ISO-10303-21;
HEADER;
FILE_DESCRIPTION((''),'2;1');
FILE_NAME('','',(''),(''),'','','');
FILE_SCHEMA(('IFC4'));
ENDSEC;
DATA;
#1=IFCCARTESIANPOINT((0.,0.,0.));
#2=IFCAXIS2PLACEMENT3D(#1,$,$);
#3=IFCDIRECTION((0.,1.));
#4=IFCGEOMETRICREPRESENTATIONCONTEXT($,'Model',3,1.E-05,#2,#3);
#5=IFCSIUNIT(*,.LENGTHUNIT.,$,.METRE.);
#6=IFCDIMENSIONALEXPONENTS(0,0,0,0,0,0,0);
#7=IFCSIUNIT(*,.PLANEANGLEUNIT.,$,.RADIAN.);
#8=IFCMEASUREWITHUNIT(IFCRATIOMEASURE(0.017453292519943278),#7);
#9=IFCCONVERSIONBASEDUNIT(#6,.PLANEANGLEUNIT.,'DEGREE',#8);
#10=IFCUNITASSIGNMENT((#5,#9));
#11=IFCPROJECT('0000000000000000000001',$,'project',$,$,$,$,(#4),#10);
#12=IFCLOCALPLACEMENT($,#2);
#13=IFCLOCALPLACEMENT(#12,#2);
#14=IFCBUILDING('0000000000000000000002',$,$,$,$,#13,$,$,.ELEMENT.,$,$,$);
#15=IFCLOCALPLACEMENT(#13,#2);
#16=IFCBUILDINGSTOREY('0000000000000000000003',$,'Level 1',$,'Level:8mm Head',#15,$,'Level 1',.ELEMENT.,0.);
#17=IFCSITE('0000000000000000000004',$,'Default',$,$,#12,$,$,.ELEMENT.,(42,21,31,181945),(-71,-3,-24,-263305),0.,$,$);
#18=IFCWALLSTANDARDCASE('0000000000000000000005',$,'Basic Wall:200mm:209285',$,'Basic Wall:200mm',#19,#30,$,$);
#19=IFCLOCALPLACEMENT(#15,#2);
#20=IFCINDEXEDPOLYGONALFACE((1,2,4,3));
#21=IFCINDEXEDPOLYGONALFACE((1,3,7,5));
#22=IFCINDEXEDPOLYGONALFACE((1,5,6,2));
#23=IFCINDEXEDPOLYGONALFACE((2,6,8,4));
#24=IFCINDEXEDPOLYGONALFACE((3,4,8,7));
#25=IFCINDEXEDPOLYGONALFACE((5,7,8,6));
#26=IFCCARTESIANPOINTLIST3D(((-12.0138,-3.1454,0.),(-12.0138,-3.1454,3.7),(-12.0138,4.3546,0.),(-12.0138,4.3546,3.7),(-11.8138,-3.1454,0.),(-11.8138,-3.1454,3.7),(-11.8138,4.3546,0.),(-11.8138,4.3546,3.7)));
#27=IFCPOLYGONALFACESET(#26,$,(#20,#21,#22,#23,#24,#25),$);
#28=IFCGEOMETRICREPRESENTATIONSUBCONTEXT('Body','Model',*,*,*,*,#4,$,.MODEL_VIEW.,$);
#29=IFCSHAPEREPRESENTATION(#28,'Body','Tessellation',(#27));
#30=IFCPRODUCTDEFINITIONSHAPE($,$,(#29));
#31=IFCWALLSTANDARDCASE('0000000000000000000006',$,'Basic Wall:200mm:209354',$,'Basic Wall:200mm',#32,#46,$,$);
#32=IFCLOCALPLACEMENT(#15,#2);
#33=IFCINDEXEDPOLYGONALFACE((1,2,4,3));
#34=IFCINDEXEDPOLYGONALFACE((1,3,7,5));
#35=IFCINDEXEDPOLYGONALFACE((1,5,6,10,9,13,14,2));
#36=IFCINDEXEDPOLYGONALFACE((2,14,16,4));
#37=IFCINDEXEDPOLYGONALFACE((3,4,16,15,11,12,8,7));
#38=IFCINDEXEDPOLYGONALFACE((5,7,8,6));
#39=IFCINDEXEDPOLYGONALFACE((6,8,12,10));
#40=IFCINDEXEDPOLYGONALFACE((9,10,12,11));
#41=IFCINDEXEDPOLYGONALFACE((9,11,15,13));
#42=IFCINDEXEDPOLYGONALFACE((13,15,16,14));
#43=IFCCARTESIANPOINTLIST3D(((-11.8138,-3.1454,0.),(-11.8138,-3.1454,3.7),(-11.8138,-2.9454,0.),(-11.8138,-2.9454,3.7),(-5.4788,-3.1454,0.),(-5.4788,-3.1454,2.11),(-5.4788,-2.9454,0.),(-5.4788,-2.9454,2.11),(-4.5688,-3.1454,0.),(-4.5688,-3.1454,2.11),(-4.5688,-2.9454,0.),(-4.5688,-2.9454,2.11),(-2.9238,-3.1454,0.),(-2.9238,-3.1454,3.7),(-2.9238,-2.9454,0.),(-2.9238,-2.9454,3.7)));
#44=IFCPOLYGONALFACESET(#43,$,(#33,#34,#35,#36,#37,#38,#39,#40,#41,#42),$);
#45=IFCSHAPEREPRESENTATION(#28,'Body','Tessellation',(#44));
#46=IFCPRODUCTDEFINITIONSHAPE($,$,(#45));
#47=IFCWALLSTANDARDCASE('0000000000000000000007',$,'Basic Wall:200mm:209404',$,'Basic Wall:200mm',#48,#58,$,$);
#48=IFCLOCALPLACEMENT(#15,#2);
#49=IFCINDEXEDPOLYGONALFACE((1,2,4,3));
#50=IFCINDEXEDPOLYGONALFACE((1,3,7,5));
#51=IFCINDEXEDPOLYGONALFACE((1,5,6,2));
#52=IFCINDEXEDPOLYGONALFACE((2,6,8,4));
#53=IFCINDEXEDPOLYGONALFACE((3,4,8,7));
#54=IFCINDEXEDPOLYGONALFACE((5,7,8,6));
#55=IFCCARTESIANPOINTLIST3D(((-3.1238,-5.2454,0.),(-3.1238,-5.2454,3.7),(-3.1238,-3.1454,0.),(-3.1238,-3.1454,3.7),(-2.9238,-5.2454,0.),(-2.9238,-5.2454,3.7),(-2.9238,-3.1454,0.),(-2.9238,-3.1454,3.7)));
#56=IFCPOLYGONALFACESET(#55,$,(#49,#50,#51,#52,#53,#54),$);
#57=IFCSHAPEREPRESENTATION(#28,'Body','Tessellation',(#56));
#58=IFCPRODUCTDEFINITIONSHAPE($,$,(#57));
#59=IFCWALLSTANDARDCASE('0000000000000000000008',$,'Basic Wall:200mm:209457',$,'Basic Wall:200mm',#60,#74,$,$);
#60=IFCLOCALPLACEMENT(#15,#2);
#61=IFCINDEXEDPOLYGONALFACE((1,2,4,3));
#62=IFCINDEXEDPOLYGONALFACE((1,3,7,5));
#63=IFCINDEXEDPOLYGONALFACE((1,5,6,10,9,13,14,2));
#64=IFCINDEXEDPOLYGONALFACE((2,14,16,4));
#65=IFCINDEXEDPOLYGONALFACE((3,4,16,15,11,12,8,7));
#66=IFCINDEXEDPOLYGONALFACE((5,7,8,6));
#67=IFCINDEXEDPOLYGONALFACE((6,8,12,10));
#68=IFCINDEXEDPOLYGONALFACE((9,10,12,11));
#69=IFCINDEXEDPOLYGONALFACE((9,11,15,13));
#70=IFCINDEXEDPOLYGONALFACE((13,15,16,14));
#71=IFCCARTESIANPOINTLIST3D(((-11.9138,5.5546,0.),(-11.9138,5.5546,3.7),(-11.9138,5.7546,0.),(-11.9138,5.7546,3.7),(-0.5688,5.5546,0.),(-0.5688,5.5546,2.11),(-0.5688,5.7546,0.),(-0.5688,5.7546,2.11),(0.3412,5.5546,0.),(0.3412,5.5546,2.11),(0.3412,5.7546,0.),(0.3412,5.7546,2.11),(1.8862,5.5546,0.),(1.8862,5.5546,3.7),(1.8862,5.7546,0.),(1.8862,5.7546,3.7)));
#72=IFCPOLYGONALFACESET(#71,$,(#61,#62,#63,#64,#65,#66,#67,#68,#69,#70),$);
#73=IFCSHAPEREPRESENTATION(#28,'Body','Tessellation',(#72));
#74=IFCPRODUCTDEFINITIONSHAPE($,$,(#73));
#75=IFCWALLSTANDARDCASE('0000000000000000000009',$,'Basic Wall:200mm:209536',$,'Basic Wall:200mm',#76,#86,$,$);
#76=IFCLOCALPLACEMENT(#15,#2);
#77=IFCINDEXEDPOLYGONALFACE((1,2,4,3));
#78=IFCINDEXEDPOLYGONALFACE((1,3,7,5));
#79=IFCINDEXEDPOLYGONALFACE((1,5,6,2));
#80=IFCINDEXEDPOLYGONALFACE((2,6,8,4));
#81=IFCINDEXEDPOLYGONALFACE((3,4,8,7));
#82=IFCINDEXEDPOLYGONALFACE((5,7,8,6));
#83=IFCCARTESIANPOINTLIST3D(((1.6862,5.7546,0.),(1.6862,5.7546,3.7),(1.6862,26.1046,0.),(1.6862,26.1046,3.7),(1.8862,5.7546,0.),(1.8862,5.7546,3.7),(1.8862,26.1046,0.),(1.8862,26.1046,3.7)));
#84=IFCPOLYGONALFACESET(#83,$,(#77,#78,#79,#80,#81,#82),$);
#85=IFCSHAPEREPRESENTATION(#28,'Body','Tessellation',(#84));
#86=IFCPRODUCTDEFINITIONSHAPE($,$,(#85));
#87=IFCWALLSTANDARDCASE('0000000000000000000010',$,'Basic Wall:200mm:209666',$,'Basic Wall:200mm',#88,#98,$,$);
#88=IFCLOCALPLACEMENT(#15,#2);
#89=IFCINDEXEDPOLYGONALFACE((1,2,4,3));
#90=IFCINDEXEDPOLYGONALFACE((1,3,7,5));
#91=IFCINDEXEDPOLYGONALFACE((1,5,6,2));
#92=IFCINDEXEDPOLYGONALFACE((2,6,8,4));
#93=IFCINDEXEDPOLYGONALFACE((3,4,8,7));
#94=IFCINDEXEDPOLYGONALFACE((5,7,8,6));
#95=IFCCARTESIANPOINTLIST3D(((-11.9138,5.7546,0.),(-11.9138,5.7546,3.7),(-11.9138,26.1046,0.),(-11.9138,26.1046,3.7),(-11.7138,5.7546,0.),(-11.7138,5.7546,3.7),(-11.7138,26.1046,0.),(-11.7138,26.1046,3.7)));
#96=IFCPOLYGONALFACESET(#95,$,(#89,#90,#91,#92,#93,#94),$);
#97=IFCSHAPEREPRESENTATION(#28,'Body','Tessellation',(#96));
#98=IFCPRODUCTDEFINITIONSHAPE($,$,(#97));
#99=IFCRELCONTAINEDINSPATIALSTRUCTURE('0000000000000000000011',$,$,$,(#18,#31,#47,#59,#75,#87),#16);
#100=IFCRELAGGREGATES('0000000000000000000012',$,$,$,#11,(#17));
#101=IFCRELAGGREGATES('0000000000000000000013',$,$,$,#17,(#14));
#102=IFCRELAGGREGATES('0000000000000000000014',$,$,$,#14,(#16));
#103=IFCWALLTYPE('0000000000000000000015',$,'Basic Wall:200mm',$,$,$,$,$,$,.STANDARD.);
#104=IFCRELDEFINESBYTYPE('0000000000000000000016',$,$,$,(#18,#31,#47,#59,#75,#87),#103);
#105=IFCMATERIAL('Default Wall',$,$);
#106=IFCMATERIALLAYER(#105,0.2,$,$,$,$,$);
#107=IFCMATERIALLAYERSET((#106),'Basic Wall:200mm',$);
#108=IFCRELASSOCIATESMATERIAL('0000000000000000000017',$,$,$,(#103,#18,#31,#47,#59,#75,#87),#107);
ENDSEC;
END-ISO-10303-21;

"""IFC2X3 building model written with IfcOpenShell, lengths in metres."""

from ifc_helpers import new_model, entity, si_unit, converted_unit, direction, frame, frame_2d, origin, place, context, subcontext, project, spatial, polyline, rectangle, extrude, clip, bounded_halfspace, material, layer, layer_set, layer_usage, type_object, element, save


model = new_model("IFC2X3")

# Units and contexts
model_context = context("Model", 3, precision=1e-05, world=origin(), true_north=direction((0.0, 1.0)))
body_context = subcontext(model_context, "Body", "Model", "MODEL_VIEW")
ifc_project = project(units=[si_unit("LENGTHUNIT", "METRE"), converted_unit("PLANEANGLEUNIT", "DEGREE", entity("IfcRatioMeasure", 0.017453292519943278), si_unit("PLANEANGLEUNIT", "RADIAN"), dimensions=[0, 0, 0, 0, 0, 0, 0])], contexts=[model_context])

# Site, building, storey
site_placement = place(None, origin())
site = spatial("IfcSite", under=ifc_project, at=site_placement, Name="Default", CompositionType="ELEMENT", RefLatitude=(42, 21, 31, 181945), RefLongitude=(-71, -3, -24, -263305), RefElevation=0.0)
building_placement = place(site_placement, origin())
building = spatial("IfcBuilding", under=site, at=building_placement, CompositionType="ELEMENT")
storey_placement = place(building_placement, origin())
storey = spatial("IfcBuildingStorey", under=building, at=storey_placement, Name="Level 1", ObjectType="Level:8mm Head", LongName="Level 1", CompositionType="ELEMENT", Elevation=0.0)

# Shared definitions
ifc_material_1 = material(Name="Default Wall")
ifc_layer_1 = layer(ifc_material_1, 0.2)
ifc_layer_set_1 = layer_set([ifc_layer_1], Name="Basic Wall:200mm")
wall_type_1 = type_object("IfcWallType", Name="Basic Wall:200mm", PredefinedType="STANDARD", material=ifc_layer_set_1)

# Wall
ifc_layer_usage_1 = layer_usage(ifc_layer_set_1, "AXIS2", "NEGATIVE", 0.1)
wall_1_placement = place(storey_placement, frame((-11.9138, 4.3546, 0.0), z_axis=(0.0, 0.0, 1.0), x_axis=(0.0, -1.0, 0.0)))
element("IfcWallStandardCase", 1, at=wall_1_placement, inside=storey, type_object=wall_type_1, material=ifc_layer_usage_1, Name="Basic Wall:200mm:209285", ObjectType="Basic Wall:200mm", context=body_context, shape_type="Clipping", body=[
    clip(extrude(rectangle(XDim=7.5, YDim=0.2, at=frame_2d((3.75, 0.0), x_axis=(-1.0, 0.0))), origin(), (0.0, 0.0, 1.0), 3.7), bounded_halfspace(frame((0.0, -0.1, 3.7), z_axis=(0.0, 0.0, -1.0), x_axis=(1.0, 0.0, 0.0)), True, frame((0.0, -0.1, 3.7), z_axis=(0.0, 0.0, -1.0), x_axis=(1.0, 0.0, 0.0)), polyline([(0.0, 0.0), (0.0, -0.2), (7.3, -0.2), (7.5, -0.2), (7.5, 0.0), (0.0, 0.0)]))),
])

# Wall, opening
ifc_layer_usage_2 = layer_usage(ifc_layer_set_1, "AXIS2", "NEGATIVE", 0.1)
wall_2_placement = place(storey_placement, frame((-11.8138, -3.0454, 0.0)))
wall_2 = element("IfcWallStandardCase", 2, at=wall_2_placement, inside=storey, type_object=wall_type_1, material=ifc_layer_usage_2, Name="Basic Wall:200mm:209354", ObjectType="Basic Wall:200mm", context=body_context, shape_type="Clipping", body=[
    clip(extrude(rectangle(XDim=0.2, YDim=8.89, at=frame_2d((4.445, 0.0), x_axis=(0.0, 1.0))), origin(), (0.0, 0.0, 1.0), 3.7), bounded_halfspace(frame((0.0, -0.1, 3.7), z_axis=(0.0, 0.0, -1.0), x_axis=(0.0, -1.0, 0.0)), True, frame((0.0, -0.1, 3.7), z_axis=(0.0, 0.0, -1.0), x_axis=(0.0, -1.0, 0.0)), polyline([(0.0, 0.0), (-0.2, 0.0), (-0.2, -8.89), (0.0, -8.89), (0.0, -8.69), (0.0, 0.0)]))),
])
opening_1_placement = place(wall_2_placement, frame((6.335, -0.1, 0.0)))
element("IfcOpeningElement", 3, at=opening_1_placement, cuts=wall_2, ObjectType="Opening", context=body_context, shape_type="SweptSolid", body=[
    extrude(rectangle(XDim=2.11, YDim=0.91, at=frame_2d((1.055, 0.455), x_axis=(1.0, 0.0))), frame((0.0, 0.0, 0.0), z_axis=(0.0, 1.0, 0.0), x_axis=(0.0, 0.0, 1.0)), (0.0, 0.0, 1.0), 0.2),
])

# Wall
ifc_layer_usage_3 = layer_usage(ifc_layer_set_1, "AXIS2", "NEGATIVE", 0.1)
wall_3_placement = place(storey_placement, frame((-3.0238, -3.1454, 0.0), z_axis=(0.0, 0.0, 1.0), x_axis=(0.0, -1.0, 0.0)))
element("IfcWallStandardCase", 4, at=wall_3_placement, inside=storey, type_object=wall_type_1, material=ifc_layer_usage_3, Name="Basic Wall:200mm:209404", ObjectType="Basic Wall:200mm", context=body_context, shape_type="Clipping", body=[
    clip(extrude(rectangle(XDim=2.1, YDim=0.2, at=frame_2d((1.05, 0.0), x_axis=(-1.0, 0.0))), origin(), (0.0, 0.0, 1.0), 3.7), bounded_halfspace(frame((0.0, -0.1, 3.7), z_axis=(0.0, 0.0, -1.0), x_axis=(1.0, 0.0, 0.0)), True, frame((0.0, -0.1, 3.7), z_axis=(0.0, 0.0, -1.0), x_axis=(1.0, 0.0, 0.0)), polyline([(0.0, 0.0), (0.0, -0.2), (2.1, -0.2), (2.1, 0.0), (0.0, 0.0)]))),
])

# Wall, opening
ifc_layer_usage_4 = layer_usage(ifc_layer_set_1, "AXIS2", "NEGATIVE", 0.1)
wall_4_placement = place(storey_placement, frame((1.8862, 5.6546, 0.0), z_axis=(0.0, 0.0, 1.0), x_axis=(-1.0, 0.0, 0.0)))
wall_4 = element("IfcWallStandardCase", 5, at=wall_4_placement, inside=storey, type_object=wall_type_1, material=ifc_layer_usage_4, Name="Basic Wall:200mm:209457", ObjectType="Basic Wall:200mm", context=body_context, shape_type="Clipping", body=[
    clip(extrude(rectangle(XDim=0.2, YDim=13.8, at=frame_2d((6.9, 0.0), x_axis=(0.0, 1.0))), origin(), (0.0, 0.0, 1.0), 3.7), bounded_halfspace(frame((0.0, -0.1, 3.7), z_axis=(0.0, 0.0, -1.0), x_axis=(0.0, 1.0, 0.0)), True, frame((0.0, -0.1, 3.7), z_axis=(0.0, 0.0, -1.0), x_axis=(0.0, 1.0, 0.0)), polyline([(0.0, 0.0), (0.2, 0.0), (0.2, 13.8), (0.0, 13.8), (0.0, 13.6), (0.0, 0.2), (0.0, 0.0)]))),
])
opening_2_placement = place(wall_4_placement, frame((2.455, 0.1, 0.0)))
element("IfcOpeningElement", 6, at=opening_2_placement, cuts=wall_4, ObjectType="Opening", context=body_context, shape_type="SweptSolid", body=[
    extrude(rectangle(XDim=2.11, YDim=0.91, at=frame_2d((1.055, 0.455), x_axis=(1.0, 0.0))), frame((0.0, 0.0, 0.0), z_axis=(0.0, -1.0, 0.0), x_axis=(0.0, 0.0, 1.0)), (0.0, 0.0, 1.0), 0.2),
])

# Walls
ifc_layer_usage_5 = layer_usage(ifc_layer_set_1, "AXIS2", "NEGATIVE", 0.1)
wall_5_placement = place(storey_placement, frame((1.7862, 5.7546, 0.0), z_axis=(0.0, 0.0, 1.0), x_axis=(0.0, 1.0, 0.0)))
element("IfcWallStandardCase", 7, at=wall_5_placement, inside=storey, type_object=wall_type_1, material=ifc_layer_usage_5, Name="Basic Wall:200mm:209536", ObjectType="Basic Wall:200mm", context=body_context, shape_type="Clipping", body=[
    clip(extrude(rectangle(XDim=20.35, YDim=0.2, at=frame_2d((10.175, 0.0), x_axis=(-1.0, 0.0))), origin(), (0.0, 0.0, 1.0), 3.7), bounded_halfspace(frame((0.0, -0.1, 3.7), z_axis=(0.0, 0.0, -1.0), x_axis=(-1.0, 0.0, 0.0)), True, frame((0.0, -0.1, 3.7), z_axis=(0.0, 0.0, -1.0), x_axis=(-1.0, 0.0, 0.0)), polyline([(0.0, 0.0), (0.0, 0.2), (-20.35, 0.2), (-20.35, 0.0), (0.0, 0.0)]))),
])
ifc_layer_usage_6 = layer_usage(ifc_layer_set_1, "AXIS2", "NEGATIVE", 0.1)
wall_6_placement = place(storey_placement, frame((-11.8138, 5.7546, 0.0), z_axis=(0.0, 0.0, 1.0), x_axis=(0.0, 1.0, 0.0)))
element("IfcWallStandardCase", 8, at=wall_6_placement, inside=storey, type_object=wall_type_1, material=ifc_layer_usage_6, Name="Basic Wall:200mm:209666", ObjectType="Basic Wall:200mm", context=body_context, shape_type="Clipping", body=[
    clip(extrude(rectangle(XDim=20.35, YDim=0.2, at=frame_2d((10.175, 0.0), x_axis=(-1.0, 0.0))), origin(), (0.0, 0.0, 1.0), 3.7), bounded_halfspace(frame((0.0, -0.1, 3.7), z_axis=(0.0, 0.0, -1.0), x_axis=(-1.0, 0.0, 0.0)), True, frame((0.0, -0.1, 3.7), z_axis=(0.0, 0.0, -1.0), x_axis=(-1.0, 0.0, 0.0)), polyline([(0.0, 0.0), (0.0, 0.2), (-20.35, 0.2), (-20.35, 0.0), (0.0, 0.0)]))),
])

save(model, "model.ifc")
